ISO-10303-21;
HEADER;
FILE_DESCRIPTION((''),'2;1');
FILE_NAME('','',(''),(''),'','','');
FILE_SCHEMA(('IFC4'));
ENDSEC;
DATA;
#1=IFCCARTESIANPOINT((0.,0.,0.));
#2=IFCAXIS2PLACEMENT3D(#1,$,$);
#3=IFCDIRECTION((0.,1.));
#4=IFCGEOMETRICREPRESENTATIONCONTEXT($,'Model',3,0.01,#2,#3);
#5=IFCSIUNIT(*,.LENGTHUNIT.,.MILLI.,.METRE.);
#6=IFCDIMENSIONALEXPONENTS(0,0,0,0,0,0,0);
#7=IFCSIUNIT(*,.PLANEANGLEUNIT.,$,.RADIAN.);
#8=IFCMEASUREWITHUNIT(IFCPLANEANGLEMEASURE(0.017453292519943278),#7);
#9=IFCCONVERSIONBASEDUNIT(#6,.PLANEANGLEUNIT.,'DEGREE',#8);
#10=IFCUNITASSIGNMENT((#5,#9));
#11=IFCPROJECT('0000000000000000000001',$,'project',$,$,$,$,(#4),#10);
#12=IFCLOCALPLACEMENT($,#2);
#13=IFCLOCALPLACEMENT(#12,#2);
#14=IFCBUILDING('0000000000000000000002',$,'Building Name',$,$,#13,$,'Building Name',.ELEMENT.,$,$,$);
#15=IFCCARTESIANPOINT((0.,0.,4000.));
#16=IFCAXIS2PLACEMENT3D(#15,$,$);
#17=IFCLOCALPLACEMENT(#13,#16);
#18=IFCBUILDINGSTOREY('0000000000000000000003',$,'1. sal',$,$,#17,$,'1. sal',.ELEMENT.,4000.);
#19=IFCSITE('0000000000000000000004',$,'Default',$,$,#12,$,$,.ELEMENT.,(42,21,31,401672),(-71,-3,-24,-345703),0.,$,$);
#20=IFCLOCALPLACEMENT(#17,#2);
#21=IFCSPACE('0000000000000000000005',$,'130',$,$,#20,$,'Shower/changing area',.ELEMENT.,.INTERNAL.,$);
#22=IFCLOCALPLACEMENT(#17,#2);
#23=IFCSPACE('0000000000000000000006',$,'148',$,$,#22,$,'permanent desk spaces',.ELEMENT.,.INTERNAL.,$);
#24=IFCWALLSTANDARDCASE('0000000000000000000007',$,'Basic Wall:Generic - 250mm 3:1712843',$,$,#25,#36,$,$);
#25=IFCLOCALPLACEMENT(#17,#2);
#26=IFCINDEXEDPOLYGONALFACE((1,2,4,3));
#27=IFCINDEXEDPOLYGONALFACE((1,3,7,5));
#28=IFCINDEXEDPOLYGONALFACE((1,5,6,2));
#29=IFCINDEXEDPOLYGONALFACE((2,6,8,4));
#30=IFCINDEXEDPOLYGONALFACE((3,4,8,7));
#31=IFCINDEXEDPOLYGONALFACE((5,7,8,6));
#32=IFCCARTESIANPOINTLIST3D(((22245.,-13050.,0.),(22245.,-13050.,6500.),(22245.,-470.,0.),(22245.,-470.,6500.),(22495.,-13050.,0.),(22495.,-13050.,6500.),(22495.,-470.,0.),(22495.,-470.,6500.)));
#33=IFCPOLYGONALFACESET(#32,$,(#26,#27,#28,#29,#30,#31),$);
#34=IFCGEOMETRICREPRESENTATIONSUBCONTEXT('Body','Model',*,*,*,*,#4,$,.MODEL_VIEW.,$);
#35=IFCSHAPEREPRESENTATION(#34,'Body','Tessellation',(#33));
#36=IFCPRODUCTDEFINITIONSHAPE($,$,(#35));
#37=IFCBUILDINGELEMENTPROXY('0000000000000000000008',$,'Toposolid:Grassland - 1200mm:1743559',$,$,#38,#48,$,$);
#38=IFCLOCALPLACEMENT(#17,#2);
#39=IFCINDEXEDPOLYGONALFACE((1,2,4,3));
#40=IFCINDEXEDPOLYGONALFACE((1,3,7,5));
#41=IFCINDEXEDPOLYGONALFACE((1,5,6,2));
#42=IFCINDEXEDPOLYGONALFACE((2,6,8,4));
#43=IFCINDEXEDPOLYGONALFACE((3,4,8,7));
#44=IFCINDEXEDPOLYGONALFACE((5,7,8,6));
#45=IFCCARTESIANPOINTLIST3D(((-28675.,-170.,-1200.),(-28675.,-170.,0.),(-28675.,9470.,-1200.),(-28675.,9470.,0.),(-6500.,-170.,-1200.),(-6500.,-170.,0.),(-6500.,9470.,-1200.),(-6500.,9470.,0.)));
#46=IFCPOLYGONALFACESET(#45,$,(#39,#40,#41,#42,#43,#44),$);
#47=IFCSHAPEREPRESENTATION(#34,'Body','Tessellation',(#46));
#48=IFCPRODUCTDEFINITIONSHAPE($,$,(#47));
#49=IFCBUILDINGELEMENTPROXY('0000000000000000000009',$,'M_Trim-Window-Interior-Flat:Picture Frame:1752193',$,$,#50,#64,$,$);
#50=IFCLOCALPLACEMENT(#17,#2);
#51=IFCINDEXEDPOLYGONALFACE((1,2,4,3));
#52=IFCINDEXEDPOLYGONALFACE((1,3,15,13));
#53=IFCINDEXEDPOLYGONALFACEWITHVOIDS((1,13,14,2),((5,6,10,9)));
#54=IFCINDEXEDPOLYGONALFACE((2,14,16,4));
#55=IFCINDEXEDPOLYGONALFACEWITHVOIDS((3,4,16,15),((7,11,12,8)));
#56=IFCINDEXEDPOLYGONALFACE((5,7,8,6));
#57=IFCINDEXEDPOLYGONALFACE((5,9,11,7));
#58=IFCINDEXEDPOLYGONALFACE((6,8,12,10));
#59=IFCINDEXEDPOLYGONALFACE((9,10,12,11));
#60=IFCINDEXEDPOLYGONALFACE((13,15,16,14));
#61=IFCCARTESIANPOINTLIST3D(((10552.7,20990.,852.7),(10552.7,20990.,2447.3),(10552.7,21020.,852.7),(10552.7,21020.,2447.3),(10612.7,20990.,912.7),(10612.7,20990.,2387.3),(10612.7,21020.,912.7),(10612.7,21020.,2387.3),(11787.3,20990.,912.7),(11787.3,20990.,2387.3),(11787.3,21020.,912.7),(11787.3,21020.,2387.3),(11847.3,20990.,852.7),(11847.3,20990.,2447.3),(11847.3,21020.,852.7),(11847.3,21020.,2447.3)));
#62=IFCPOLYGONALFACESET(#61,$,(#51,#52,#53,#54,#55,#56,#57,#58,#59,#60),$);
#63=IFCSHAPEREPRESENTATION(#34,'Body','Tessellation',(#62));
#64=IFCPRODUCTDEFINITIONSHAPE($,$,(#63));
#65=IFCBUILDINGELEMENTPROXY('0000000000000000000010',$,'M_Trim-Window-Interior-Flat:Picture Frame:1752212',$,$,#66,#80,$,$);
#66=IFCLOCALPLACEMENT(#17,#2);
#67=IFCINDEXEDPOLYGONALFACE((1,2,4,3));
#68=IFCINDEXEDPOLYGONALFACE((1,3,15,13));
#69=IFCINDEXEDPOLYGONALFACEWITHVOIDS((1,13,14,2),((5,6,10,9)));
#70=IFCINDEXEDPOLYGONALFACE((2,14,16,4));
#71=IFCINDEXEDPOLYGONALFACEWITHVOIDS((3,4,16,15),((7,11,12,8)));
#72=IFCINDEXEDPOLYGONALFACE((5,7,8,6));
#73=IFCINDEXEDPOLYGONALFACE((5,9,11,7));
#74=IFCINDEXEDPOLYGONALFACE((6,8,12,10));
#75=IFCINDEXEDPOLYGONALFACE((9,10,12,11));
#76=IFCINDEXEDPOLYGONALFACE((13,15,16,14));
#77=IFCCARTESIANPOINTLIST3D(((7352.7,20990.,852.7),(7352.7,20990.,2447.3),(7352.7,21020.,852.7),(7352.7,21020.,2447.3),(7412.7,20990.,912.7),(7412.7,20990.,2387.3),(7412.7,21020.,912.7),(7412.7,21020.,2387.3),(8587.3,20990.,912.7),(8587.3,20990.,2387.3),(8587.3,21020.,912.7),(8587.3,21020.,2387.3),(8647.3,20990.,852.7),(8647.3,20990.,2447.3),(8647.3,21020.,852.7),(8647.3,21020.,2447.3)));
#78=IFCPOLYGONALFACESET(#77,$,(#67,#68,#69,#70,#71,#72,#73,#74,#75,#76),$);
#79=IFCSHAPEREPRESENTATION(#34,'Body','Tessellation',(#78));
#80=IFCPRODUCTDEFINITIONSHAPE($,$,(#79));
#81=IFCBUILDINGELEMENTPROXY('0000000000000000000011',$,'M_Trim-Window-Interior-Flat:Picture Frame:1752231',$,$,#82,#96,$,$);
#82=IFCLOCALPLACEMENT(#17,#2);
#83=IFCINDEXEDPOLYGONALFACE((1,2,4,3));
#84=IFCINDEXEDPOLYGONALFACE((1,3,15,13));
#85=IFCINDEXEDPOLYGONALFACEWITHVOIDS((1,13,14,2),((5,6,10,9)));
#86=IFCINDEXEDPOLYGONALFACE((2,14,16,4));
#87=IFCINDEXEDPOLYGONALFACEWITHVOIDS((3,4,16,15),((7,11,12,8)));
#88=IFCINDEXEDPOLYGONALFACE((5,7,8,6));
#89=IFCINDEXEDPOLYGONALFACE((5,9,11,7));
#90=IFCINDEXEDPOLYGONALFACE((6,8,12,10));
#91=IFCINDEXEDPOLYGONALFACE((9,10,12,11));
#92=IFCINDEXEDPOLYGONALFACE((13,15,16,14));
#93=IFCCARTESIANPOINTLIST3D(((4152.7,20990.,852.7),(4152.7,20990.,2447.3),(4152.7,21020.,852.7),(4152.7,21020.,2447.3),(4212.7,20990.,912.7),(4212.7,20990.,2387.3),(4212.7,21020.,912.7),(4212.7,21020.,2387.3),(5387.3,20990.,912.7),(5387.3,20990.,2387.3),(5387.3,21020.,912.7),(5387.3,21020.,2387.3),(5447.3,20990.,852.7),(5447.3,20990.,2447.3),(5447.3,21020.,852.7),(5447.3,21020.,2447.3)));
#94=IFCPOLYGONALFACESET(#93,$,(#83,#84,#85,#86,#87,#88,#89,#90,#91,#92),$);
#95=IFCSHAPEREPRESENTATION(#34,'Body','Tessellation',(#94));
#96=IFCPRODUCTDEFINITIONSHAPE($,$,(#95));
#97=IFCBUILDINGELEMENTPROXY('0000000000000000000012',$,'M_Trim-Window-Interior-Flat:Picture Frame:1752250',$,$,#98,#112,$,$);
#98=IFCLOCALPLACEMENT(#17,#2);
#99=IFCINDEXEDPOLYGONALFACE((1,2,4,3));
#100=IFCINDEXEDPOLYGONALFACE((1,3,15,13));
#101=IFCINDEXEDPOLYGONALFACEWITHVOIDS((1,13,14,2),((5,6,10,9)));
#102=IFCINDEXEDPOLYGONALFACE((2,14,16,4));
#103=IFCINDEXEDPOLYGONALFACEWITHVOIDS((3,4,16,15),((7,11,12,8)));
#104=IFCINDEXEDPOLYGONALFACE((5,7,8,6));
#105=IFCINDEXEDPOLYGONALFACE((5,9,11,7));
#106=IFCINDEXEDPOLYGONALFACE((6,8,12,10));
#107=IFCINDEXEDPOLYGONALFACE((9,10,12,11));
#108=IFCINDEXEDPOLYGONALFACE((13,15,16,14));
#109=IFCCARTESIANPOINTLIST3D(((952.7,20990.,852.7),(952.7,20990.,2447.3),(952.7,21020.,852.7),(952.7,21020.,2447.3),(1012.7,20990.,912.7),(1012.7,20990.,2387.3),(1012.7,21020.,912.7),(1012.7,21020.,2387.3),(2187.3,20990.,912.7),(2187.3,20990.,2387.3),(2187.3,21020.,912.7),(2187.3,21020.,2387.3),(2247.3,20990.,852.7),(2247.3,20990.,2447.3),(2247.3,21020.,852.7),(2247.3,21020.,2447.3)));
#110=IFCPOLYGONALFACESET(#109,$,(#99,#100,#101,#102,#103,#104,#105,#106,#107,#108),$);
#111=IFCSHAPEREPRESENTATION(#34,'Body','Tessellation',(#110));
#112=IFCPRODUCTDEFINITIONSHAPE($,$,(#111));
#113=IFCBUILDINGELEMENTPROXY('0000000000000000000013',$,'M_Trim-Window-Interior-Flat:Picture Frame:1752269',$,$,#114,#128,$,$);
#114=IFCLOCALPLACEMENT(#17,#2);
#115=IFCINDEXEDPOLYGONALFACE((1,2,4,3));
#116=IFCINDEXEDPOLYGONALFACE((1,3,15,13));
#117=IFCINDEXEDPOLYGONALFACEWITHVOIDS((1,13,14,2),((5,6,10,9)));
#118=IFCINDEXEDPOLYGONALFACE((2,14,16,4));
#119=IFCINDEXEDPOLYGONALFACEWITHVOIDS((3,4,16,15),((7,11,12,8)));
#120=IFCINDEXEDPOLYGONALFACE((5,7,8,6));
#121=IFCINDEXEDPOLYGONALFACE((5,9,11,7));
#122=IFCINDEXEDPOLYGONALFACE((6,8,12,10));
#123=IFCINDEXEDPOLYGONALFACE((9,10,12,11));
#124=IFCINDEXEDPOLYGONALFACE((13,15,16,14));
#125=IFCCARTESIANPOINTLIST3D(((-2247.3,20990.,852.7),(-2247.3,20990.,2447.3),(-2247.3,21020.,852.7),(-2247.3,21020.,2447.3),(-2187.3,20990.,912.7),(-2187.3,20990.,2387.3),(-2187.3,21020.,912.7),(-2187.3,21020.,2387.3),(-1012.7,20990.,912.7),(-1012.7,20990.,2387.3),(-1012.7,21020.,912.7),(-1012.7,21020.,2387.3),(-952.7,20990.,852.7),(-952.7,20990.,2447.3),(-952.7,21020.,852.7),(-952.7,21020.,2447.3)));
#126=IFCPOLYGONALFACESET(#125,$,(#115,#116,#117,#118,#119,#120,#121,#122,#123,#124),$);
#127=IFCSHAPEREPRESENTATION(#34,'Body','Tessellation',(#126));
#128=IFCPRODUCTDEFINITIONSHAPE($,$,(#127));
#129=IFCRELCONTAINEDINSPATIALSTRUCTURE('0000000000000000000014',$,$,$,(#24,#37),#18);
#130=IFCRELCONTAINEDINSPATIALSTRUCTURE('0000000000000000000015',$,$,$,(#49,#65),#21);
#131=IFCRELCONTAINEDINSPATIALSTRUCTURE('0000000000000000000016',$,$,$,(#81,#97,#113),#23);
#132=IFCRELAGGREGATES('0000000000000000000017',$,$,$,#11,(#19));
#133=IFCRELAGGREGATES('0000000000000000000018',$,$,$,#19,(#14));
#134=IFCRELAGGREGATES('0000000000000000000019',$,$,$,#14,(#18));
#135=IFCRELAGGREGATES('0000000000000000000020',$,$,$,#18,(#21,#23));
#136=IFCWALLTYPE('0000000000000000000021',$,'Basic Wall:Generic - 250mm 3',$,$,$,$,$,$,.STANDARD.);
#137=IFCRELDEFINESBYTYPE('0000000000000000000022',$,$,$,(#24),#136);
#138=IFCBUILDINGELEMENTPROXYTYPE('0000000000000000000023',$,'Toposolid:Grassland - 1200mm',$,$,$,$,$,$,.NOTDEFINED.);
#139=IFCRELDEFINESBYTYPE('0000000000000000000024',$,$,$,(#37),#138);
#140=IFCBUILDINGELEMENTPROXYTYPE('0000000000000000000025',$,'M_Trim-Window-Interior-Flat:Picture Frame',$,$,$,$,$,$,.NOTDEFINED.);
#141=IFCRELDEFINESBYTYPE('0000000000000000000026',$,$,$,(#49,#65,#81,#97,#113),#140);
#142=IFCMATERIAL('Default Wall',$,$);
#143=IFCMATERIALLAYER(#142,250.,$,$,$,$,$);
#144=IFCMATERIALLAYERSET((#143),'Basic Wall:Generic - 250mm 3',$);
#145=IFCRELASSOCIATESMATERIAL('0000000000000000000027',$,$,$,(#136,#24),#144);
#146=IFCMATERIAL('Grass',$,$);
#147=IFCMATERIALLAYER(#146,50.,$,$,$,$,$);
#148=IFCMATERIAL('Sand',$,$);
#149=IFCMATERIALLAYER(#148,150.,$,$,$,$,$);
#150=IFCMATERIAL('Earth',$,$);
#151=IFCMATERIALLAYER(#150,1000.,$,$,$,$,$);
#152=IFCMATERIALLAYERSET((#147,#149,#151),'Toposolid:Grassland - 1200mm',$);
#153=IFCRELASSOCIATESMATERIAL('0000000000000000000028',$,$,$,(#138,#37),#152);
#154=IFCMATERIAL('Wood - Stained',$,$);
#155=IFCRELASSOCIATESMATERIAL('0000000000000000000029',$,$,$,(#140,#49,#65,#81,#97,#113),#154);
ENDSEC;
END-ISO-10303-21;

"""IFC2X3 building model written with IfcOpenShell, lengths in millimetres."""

from ifc_helpers import new_model, entity, si_unit, converted_unit, direction, frame, frame_2d, origin, place, context, subcontext, project, spatial, polyline, rectangle, outline, extrude, source, transform, mapped, material, layer, layer_set, layer_usage, type_object, type_shapes, element, save


model = new_model("IFC2X3")

# Units and contexts
model_context = context("Model", 3, precision=0.01, world=origin(), true_north=direction((0.0, 1.0)))
body_context = subcontext(model_context, "Body", "Model", "MODEL_VIEW")
ifc_project = project(units=[si_unit("LENGTHUNIT", "METRE", prefix="MILLI"), converted_unit("PLANEANGLEUNIT", "DEGREE", entity("IfcPlaneAngleMeasure", 0.017453292519943278), si_unit("PLANEANGLEUNIT", "RADIAN"), dimensions=[0, 0, 0, 0, 0, 0, 0])], contexts=[model_context])

# Site, building, storey
site_placement = place(None, origin())
site = spatial("IfcSite", under=ifc_project, at=site_placement, Name="Default", CompositionType="ELEMENT", RefLatitude=(42, 21, 31, 401672), RefLongitude=(-71, -3, -24, -345703), RefElevation=0.0)
building_placement = place(site_placement, origin())
building = spatial("IfcBuilding", under=site, at=building_placement, Name="Building Name", LongName="Building Name", CompositionType="ELEMENT")
storey_placement = place(building_placement, frame((0.0, 0.0, 4000.0)))
storey = spatial("IfcBuildingStorey", under=building, at=storey_placement, Name="1. sal", LongName="1. sal", CompositionType="ELEMENT", Elevation=4000.0)

# Shared definitions
ifc_material_1 = material(Name="Default Wall")

# Wall
ifc_layer_1 = layer(ifc_material_1, 250.0)
ifc_layer_set_1 = layer_set([ifc_layer_1], Name="Basic Wall:Generic - 250mm 3")
ifc_layer_usage_1 = layer_usage(ifc_layer_set_1, "AXIS2", "NEGATIVE", 125.0)
wall_type_1 = type_object("IfcWallType", Name="Basic Wall:Generic - 250mm 3", PredefinedType="STANDARD", material=ifc_layer_set_1)
wall_1_placement = place(storey_placement, frame((22370.0, -13050.0, 0.0), z_axis=(0.0, 0.0, 1.0), x_axis=(0.0, 1.0, 0.0)))
element("IfcWallStandardCase", 1, at=wall_1_placement, inside=storey, type_object=wall_type_1, material=ifc_layer_usage_1, Name="Basic Wall:Generic - 250mm 3:1712843", context=body_context, shape_type="SweptSolid", body=[
    extrude(rectangle(XDim=12580.0, YDim=250.0, at=frame_2d((6290.0, 0.0), x_axis=(-1.0, 0.0))), origin(), (0.0, 0.0, 1.0), 6500.0),
])

# Building element proxy
ifc_material_2 = material(Name="Grass")
ifc_layer_2 = layer(ifc_material_2, 50.0)
ifc_material_3 = material(Name="Sand")
ifc_layer_3 = layer(ifc_material_3, 150.0)
ifc_material_4 = material(Name="Earth")
ifc_layer_4 = layer(ifc_material_4, 1000.0)
ifc_layer_set_2 = layer_set([ifc_layer_2, ifc_layer_3, ifc_layer_4], Name="Toposolid:Grassland - 1200mm")
ifc_layer_usage_2 = layer_usage(ifc_layer_set_2, "AXIS3", "NEGATIVE", 0.0)
building_element_proxy_type_1 = type_object("IfcBuildingElementProxyType", Name="Toposolid:Grassland - 1200mm", PredefinedType="NOTDEFINED", material=ifc_layer_set_2)
proxy_placement = place(storey_placement, origin())
element("IfcBuildingElementProxy", 2, at=proxy_placement, inside=storey, type_object=building_element_proxy_type_1, material=ifc_layer_usage_2, Name="Toposolid:Grassland - 1200mm:1743559", context=body_context, shape_type="SweptSolid", body=[
    extrude(rectangle(XDim=22175.0, YDim=9640.0, at=frame_2d((0.0, 0.0), x_axis=(1.0, 0.0))), frame((-17587.5, 4650.0, -1200.0), z_axis=(0.0, 0.0, 1.0), x_axis=(-1.0, 0.0, 0.0)), (0.0, 0.0, 1.0), 1200.0),
])

# Shared definitions
space_1_placement = place(storey_placement, origin())
space_1 = spatial("IfcSpace", under=storey, at=space_1_placement, Name="130", LongName="Shower/changing area", CompositionType="ELEMENT", InteriorOrExteriorSpace="INTERNAL")

# Building element proxies
ifc_material_5 = material(Name="Wood - Stained")
building_element_proxy_type_2 = type_object("IfcBuildingElementProxyType", Name="M_Trim-Window-Interior-Flat:Picture Frame", PredefinedType="NOTDEFINED", material=ifc_material_5)
shared_shape_1 = source(origin(), body_context, "Body", "SweptSolid", [
    extrude(outline(polyline([(-647.3, -797.3), (647.3, -797.3), (647.3, 797.3), (-647.3, 797.3), (-647.3, -797.3)]), holes=[polyline([(-587.3, -737.3), (-587.3, 737.3), (587.3, 737.3), (587.3, -737.3), (-587.3, -737.3)])]), frame((0.0, -750.0, 0.0), z_axis=(0.0, 0.0, 1.0), x_axis=(-1.0, 0.0, 0.0)), (0.0, 0.0, 1.0), 30.0),
])
type_shapes(building_element_proxy_type_2, [shared_shape_1])
for number, where, z_axis, x_axis, name in (
    (3, (11200.0, 21020.0, 2400.0), (0.0, -1.0, 0.0), (1.0, 0.0, 0.0), "M_Trim-Window-Interior-Flat:Picture Frame:1752193"),
    (4, (8000.0, 21020.0, 2400.0), (0.0, -1.0, 0.0), (1.0, 0.0, 0.0), "M_Trim-Window-Interior-Flat:Picture Frame:1752212"),
):
    element("IfcBuildingElementProxy", number, at=place(space_1_placement, frame(where, z_axis=z_axis, x_axis=x_axis)), inside=space_1, type_object=building_element_proxy_type_2, material=ifc_material_5, Name=name, context=body_context, shape_type="MappedRepresentation", body=[
        mapped(shared_shape_1, transform((0.0, 0.0, 0.0), scale=1.0)),
    ])

# Shared definitions
space_2_placement = place(storey_placement, origin())
space_2 = spatial("IfcSpace", under=storey, at=space_2_placement, Name="148", LongName="permanent desk spaces", CompositionType="ELEMENT", InteriorOrExteriorSpace="INTERNAL")

# Building element proxies
for number, where, z_axis, x_axis, name in (
    (5, (4800.0, 21020.0, 2400.0), (0.0, -1.0, 0.0), (1.0, 0.0, 0.0), "M_Trim-Window-Interior-Flat:Picture Frame:1752231"),
    (6, (1600.0, 21020.0, 2400.0), (0.0, -1.0, 0.0), (1.0, 0.0, 0.0), "M_Trim-Window-Interior-Flat:Picture Frame:1752250"),
    (7, (-1600.0, 21020.0, 2400.0), (0.0, -1.0, 0.0), (1.0, 0.0, 0.0), "M_Trim-Window-Interior-Flat:Picture Frame:1752269"),
):
    element("IfcBuildingElementProxy", number, at=place(space_2_placement, frame(where, z_axis=z_axis, x_axis=x_axis)), inside=space_2, type_object=building_element_proxy_type_2, material=ifc_material_5, Name=name, context=body_context, shape_type="MappedRepresentation", body=[
        mapped(shared_shape_1, transform((0.0, 0.0, 0.0), scale=1.0)),
    ])

save(model, "model.ifc")
